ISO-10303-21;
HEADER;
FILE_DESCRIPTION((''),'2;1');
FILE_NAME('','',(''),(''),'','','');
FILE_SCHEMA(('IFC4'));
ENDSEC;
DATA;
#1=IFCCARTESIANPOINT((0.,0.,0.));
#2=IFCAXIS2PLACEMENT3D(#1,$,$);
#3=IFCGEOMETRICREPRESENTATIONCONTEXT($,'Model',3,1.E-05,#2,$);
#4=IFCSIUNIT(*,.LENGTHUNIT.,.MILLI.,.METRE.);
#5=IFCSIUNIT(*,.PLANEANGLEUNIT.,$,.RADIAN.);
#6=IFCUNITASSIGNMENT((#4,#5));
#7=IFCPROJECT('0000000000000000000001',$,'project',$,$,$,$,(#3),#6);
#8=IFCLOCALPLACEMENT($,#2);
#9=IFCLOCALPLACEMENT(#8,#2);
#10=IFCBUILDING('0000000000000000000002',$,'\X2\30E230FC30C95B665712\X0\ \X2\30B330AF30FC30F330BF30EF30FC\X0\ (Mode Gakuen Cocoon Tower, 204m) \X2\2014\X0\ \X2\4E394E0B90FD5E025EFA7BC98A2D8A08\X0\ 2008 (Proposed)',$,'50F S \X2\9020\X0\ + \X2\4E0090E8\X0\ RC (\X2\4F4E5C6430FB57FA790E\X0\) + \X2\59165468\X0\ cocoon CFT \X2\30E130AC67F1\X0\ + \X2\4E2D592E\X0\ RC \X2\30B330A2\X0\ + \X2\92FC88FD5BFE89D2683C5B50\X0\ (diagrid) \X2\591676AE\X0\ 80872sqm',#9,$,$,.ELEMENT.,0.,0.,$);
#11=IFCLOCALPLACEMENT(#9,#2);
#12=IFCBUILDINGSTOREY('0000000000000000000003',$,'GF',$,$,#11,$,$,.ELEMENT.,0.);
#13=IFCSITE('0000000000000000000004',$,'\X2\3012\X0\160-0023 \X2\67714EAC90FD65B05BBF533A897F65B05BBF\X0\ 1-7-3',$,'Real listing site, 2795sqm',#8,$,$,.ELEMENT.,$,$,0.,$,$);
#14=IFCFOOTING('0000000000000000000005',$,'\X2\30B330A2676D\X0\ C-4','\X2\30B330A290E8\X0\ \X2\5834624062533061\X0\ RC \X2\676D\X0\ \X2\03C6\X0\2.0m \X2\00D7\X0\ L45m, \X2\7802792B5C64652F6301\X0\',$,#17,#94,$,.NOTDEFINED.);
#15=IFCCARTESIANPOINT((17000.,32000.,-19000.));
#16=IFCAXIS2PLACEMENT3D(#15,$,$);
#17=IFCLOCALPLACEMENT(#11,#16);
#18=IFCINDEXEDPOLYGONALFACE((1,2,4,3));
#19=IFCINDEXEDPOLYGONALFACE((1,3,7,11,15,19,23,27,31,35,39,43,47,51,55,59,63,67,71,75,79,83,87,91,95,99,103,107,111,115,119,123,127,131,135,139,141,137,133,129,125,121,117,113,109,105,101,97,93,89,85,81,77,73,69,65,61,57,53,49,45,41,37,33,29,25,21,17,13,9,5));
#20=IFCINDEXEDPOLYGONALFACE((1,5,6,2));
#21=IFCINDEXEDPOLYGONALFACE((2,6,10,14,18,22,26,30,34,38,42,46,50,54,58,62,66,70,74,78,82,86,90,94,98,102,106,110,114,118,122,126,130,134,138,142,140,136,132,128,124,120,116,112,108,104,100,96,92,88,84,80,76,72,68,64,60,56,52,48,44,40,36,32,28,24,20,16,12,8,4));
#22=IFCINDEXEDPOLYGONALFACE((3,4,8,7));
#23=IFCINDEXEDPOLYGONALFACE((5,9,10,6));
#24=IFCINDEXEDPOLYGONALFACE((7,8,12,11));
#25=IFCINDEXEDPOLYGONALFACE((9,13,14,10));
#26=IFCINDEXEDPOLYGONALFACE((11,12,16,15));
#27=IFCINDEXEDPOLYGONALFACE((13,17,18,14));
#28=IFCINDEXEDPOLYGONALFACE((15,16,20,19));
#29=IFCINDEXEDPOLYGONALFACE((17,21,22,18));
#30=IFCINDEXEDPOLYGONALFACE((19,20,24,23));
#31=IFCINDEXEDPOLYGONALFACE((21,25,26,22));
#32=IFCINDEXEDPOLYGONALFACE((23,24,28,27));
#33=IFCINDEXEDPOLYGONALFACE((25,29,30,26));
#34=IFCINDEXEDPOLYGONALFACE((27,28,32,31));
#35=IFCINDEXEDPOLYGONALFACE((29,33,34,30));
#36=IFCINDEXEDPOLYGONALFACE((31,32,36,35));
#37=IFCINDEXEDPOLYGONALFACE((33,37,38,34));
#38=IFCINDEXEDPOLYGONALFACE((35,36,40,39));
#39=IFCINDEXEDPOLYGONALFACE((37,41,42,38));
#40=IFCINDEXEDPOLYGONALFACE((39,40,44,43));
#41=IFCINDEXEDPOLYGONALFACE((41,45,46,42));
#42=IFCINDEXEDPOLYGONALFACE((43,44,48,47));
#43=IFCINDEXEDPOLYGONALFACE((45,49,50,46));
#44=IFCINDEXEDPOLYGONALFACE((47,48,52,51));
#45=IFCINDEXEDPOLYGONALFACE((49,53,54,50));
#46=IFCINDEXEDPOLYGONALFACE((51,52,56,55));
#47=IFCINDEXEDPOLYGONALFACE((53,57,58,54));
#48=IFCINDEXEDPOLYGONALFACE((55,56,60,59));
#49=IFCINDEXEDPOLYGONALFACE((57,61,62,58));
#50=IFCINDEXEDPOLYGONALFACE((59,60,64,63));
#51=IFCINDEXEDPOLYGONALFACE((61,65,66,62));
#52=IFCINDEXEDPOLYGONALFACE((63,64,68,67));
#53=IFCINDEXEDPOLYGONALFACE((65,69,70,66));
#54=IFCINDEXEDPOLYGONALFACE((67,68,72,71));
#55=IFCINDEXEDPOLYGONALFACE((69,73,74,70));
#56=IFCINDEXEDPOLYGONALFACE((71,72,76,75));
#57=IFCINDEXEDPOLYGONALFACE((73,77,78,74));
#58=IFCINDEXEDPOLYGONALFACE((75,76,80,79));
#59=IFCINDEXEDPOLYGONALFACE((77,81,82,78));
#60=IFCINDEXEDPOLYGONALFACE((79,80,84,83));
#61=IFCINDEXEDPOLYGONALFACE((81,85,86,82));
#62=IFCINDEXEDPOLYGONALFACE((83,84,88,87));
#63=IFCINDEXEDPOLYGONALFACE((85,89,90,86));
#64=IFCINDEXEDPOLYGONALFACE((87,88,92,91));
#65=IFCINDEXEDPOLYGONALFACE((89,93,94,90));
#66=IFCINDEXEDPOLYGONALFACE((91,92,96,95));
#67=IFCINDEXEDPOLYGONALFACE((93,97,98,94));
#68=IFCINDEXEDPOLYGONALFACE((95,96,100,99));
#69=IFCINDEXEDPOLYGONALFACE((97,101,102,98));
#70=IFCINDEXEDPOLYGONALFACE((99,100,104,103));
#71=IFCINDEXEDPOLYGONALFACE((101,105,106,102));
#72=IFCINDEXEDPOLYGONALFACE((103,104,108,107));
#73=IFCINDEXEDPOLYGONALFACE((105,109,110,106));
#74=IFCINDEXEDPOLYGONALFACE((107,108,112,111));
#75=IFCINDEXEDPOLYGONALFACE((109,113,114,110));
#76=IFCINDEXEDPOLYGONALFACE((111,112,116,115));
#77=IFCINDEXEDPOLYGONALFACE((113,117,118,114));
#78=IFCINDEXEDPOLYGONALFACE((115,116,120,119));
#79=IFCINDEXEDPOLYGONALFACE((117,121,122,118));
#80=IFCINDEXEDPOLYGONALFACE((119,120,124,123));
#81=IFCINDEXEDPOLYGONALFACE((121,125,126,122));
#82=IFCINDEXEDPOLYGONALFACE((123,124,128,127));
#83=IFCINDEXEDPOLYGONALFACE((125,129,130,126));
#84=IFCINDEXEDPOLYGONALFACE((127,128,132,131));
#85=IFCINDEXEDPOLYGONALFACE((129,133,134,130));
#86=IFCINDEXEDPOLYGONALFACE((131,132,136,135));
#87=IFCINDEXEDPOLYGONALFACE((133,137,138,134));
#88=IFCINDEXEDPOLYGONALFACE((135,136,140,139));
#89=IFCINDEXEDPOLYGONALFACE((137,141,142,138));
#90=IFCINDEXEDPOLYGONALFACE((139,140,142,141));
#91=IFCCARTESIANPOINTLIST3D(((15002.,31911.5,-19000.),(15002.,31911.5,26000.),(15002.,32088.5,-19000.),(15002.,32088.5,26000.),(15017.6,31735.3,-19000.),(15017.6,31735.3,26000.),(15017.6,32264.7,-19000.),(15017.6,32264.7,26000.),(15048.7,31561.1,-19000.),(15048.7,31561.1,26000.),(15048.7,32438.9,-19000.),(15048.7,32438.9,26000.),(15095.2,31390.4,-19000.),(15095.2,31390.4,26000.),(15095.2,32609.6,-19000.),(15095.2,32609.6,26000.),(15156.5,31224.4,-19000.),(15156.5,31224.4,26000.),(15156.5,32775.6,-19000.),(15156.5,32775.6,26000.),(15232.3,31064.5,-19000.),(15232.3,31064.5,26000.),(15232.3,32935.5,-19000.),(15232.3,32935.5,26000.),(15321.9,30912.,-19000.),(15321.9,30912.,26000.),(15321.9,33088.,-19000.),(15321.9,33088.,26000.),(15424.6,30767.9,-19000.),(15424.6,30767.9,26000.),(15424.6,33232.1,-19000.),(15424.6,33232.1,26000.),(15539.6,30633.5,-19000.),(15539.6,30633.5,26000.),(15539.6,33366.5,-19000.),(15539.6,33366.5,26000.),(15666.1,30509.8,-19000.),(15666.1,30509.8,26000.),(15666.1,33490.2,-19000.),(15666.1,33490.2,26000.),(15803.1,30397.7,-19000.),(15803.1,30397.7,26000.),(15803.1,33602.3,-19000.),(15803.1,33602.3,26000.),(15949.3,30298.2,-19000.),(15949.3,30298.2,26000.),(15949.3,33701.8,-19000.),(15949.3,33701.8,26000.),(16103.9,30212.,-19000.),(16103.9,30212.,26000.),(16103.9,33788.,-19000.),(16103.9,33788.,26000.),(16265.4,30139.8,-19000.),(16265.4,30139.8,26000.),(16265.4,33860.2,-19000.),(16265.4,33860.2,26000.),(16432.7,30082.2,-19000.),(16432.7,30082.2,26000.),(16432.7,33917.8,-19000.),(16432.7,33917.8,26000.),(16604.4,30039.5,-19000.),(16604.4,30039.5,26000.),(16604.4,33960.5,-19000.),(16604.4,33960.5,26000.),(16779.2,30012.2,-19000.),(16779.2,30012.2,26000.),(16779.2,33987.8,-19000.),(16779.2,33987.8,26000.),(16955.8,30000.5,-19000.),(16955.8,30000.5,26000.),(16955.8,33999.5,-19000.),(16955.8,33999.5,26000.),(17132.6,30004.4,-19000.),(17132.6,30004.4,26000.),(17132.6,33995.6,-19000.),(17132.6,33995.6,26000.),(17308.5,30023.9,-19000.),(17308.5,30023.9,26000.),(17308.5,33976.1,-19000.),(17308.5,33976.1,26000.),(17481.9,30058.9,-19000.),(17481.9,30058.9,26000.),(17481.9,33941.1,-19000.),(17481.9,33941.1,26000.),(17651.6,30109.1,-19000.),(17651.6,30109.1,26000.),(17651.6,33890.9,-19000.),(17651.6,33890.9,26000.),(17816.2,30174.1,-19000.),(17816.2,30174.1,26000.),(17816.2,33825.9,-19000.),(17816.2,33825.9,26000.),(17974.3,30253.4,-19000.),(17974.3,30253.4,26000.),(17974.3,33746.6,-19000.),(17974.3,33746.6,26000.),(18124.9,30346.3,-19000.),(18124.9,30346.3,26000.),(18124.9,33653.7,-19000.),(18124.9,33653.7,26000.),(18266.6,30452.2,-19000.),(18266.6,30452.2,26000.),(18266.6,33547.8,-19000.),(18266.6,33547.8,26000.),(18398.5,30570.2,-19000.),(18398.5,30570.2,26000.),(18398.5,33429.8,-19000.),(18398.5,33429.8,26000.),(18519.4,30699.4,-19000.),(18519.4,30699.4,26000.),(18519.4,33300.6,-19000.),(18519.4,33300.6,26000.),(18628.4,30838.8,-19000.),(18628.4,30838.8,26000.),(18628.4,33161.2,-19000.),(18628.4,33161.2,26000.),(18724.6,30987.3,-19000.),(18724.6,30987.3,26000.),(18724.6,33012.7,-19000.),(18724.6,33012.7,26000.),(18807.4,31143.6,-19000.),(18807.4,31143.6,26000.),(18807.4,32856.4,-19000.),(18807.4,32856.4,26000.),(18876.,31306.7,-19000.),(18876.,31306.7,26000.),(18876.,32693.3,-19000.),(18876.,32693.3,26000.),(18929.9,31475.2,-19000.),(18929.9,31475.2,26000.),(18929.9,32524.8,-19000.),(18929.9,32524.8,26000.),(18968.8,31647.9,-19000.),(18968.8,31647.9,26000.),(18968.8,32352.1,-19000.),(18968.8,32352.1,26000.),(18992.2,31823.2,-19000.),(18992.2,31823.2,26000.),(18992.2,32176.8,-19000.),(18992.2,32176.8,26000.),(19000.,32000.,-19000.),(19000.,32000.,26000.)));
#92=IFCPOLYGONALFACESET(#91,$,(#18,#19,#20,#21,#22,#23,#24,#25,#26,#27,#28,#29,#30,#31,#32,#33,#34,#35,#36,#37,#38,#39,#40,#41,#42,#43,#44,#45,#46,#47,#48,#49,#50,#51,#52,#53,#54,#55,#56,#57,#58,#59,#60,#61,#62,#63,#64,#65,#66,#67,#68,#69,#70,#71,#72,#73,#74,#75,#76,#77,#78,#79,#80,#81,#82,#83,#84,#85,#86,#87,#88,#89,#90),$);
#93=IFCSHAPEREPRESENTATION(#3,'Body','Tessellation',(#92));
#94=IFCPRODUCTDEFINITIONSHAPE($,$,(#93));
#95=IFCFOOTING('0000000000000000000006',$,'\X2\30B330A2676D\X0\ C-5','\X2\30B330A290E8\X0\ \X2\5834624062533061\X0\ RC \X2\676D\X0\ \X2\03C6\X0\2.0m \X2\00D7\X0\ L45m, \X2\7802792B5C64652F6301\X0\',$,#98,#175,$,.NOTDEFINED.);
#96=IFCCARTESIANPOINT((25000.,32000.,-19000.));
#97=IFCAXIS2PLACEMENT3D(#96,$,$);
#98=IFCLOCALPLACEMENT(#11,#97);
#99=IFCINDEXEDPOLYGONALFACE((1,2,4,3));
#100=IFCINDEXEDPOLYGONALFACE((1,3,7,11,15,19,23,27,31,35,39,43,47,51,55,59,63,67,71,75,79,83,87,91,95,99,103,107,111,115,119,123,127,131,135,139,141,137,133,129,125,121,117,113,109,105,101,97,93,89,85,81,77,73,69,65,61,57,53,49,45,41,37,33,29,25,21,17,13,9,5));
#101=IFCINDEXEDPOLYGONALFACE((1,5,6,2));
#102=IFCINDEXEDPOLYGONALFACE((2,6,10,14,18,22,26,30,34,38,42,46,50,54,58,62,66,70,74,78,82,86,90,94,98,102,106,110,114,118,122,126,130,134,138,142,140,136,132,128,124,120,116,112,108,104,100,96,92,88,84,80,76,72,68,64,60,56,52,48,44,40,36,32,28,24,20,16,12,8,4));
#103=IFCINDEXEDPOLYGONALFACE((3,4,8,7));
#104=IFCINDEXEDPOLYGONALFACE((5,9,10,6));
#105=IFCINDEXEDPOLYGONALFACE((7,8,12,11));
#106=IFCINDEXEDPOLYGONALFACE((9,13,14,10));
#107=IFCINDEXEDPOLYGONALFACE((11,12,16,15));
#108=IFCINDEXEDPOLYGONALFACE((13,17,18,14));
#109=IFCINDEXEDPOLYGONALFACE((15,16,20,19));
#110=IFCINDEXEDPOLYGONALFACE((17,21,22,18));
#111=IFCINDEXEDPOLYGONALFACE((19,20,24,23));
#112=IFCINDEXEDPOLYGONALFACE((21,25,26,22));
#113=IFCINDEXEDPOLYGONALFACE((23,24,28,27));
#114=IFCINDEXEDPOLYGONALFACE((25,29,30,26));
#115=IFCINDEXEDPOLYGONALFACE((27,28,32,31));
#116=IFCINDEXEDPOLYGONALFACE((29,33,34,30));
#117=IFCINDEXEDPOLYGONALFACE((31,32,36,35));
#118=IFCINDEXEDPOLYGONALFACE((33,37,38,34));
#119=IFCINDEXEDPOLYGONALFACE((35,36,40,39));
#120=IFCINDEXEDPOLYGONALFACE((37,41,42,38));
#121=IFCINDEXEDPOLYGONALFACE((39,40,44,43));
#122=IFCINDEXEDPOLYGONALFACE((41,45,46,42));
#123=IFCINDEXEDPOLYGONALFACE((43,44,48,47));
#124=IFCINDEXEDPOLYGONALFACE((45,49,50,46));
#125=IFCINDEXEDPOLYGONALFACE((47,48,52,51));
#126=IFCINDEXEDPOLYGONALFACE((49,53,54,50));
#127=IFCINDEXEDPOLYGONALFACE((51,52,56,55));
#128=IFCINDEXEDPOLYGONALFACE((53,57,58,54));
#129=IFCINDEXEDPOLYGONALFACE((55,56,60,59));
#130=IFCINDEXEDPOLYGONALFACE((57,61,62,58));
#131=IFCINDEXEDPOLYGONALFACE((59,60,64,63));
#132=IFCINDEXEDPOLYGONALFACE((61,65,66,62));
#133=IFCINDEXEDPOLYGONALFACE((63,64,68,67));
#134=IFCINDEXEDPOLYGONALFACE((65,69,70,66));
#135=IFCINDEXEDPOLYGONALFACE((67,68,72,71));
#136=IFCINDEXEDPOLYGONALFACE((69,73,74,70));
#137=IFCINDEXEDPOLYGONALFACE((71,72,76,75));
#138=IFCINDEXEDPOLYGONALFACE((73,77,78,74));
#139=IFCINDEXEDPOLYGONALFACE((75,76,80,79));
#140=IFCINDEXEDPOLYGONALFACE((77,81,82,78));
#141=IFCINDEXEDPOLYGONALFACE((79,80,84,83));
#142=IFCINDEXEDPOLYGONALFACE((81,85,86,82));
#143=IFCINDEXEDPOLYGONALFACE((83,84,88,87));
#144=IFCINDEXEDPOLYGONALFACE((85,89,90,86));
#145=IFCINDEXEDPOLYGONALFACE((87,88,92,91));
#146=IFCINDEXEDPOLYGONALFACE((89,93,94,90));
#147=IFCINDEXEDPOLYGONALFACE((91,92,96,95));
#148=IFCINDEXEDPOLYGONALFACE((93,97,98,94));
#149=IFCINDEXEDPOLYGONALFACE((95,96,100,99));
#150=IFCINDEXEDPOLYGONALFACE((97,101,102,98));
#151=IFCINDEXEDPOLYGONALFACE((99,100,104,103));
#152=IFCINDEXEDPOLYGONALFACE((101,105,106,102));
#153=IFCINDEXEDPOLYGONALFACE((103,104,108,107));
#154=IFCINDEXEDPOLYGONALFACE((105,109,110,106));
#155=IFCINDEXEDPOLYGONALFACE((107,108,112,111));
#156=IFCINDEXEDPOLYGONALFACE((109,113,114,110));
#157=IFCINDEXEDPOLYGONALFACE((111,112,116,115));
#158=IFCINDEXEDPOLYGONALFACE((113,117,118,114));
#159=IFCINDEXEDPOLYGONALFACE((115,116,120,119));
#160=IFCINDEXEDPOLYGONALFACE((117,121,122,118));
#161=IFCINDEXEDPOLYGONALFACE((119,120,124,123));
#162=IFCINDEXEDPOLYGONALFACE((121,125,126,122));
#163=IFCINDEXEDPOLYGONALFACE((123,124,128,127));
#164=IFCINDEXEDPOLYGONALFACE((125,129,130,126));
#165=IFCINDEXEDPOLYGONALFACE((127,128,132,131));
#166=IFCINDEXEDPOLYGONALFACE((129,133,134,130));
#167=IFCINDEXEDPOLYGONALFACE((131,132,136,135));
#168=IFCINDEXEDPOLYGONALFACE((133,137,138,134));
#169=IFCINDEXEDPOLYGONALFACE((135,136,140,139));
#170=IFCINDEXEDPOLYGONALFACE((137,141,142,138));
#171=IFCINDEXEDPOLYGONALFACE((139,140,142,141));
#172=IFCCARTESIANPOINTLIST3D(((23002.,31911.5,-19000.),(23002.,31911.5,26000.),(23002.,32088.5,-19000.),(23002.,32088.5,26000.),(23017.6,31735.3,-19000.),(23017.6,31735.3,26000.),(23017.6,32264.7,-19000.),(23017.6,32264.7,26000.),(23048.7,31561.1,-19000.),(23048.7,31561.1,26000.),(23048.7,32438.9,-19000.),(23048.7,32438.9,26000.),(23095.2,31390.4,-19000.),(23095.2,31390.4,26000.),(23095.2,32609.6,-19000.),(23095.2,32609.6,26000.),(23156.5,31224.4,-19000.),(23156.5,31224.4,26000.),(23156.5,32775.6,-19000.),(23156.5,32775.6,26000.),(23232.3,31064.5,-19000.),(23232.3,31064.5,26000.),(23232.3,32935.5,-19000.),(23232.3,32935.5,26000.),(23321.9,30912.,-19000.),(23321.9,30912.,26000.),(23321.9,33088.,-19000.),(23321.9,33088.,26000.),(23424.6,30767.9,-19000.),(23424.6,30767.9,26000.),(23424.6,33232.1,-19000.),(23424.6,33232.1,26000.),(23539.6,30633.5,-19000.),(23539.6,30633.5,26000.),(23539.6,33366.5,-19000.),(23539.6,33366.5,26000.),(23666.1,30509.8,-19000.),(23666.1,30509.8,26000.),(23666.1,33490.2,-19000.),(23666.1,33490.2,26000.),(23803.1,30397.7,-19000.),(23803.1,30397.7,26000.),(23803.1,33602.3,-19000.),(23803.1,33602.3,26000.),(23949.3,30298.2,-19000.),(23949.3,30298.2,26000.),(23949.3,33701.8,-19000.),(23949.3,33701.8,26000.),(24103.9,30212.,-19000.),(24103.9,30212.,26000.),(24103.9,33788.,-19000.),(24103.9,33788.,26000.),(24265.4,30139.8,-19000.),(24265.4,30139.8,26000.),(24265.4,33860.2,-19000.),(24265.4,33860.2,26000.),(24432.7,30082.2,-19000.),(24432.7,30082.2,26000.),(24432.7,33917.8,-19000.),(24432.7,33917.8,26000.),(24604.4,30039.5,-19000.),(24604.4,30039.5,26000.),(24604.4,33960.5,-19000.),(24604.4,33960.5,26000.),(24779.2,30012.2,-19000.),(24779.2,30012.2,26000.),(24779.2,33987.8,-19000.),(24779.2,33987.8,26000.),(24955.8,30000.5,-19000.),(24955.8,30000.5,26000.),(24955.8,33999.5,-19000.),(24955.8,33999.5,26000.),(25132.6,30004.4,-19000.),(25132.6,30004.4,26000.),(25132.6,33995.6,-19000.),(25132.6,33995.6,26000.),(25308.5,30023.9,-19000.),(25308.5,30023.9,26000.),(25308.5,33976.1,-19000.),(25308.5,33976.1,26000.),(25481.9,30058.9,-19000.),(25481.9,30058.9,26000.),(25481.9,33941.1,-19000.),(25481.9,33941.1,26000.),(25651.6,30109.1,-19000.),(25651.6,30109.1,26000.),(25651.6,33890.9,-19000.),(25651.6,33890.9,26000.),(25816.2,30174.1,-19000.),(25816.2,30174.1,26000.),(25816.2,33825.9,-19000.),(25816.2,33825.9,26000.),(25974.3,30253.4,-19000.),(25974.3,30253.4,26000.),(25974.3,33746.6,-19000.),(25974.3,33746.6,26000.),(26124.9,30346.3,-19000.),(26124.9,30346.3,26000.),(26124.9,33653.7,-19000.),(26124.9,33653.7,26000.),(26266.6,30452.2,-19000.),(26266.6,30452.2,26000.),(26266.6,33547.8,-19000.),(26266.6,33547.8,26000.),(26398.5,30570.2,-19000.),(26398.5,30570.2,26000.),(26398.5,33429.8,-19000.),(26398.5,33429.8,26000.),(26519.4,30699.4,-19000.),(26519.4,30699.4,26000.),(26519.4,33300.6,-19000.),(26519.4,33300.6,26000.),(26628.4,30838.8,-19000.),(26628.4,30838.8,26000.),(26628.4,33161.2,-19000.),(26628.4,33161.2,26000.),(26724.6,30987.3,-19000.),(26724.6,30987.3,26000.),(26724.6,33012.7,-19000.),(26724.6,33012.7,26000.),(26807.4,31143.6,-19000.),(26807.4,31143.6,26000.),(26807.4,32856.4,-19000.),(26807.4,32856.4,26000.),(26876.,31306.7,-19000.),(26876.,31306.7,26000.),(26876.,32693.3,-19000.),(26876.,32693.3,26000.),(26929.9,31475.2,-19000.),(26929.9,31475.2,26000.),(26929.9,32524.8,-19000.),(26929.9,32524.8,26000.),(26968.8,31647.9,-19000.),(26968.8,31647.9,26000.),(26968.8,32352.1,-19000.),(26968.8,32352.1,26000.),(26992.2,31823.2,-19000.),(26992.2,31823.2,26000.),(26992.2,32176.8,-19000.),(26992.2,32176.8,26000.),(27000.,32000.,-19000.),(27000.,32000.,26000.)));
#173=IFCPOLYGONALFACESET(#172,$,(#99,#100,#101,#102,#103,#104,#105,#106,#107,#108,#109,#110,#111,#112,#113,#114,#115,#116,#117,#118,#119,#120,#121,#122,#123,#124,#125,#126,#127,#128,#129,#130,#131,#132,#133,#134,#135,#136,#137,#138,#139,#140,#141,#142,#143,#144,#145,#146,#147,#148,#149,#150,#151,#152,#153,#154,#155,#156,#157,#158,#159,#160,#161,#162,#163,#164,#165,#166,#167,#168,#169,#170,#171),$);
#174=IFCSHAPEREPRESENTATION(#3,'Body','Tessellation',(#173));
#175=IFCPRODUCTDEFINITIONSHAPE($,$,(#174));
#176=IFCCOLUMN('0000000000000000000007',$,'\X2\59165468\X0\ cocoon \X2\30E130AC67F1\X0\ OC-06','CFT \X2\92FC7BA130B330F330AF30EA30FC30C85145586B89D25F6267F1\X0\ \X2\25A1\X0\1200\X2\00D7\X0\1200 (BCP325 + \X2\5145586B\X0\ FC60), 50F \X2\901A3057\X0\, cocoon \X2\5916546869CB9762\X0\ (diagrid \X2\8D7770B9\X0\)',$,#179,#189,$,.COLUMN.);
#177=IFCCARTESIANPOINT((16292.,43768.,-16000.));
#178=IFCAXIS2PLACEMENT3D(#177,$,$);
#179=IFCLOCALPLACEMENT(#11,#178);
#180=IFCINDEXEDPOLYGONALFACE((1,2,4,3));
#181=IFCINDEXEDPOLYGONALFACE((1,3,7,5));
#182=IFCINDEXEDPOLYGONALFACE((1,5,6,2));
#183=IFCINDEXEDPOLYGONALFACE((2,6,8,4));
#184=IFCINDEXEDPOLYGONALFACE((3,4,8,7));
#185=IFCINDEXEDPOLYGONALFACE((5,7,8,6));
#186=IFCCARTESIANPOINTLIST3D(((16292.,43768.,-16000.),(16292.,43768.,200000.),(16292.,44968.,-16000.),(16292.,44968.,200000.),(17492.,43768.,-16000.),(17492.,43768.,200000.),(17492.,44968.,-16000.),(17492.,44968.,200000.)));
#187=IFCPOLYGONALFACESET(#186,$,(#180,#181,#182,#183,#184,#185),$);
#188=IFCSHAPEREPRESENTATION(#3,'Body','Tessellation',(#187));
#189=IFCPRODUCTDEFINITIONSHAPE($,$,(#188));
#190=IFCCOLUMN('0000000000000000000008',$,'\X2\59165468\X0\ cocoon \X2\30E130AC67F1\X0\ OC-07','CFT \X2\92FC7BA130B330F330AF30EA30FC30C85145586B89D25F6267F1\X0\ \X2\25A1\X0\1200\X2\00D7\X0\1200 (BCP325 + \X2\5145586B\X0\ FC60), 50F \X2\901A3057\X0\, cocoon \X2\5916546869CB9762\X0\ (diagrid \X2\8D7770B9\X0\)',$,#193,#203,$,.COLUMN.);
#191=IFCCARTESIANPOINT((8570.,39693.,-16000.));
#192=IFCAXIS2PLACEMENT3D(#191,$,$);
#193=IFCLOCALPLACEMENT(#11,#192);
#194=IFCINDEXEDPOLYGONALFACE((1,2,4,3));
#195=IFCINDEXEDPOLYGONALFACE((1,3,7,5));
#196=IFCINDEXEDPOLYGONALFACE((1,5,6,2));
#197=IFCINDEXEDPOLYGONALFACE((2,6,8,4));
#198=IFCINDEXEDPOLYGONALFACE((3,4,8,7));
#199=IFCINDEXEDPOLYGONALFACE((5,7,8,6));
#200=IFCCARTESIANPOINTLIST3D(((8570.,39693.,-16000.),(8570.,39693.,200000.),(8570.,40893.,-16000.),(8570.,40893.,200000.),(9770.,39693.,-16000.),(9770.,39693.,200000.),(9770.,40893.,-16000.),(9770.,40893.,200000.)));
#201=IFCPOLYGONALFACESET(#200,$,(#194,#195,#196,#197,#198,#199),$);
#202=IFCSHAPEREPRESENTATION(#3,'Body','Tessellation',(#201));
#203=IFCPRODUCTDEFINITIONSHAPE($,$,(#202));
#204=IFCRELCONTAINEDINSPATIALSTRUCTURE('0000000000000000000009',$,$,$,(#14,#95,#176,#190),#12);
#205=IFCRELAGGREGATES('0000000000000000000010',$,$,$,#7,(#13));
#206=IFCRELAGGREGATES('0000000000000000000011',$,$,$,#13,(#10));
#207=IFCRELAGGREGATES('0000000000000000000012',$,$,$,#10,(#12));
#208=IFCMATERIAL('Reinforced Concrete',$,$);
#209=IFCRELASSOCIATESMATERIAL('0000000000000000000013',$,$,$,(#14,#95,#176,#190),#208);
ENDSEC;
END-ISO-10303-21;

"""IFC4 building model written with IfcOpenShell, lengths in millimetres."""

from ifc_helpers import new_model, si_unit, frame, frame_2d, origin, origin_2d, place, context, project, spatial, rectangle, circle, extrude, material, element, save


model = new_model("IFC4")

# Units and contexts
model_context = context("Model", 3, precision=1e-05, world=origin())
ifc_project = project(units=[si_unit("LENGTHUNIT", "METRE", prefix="MILLI"), si_unit("PLANEANGLEUNIT", "RADIAN")], contexts=[model_context])

# Site, building, storey
site_placement = place(None, origin())
site = spatial("IfcSite", under=ifc_project, at=site_placement, Name="〒160-0023 東京都新宿区西新宿 1-7-3", ObjectType="Real listing site, 2795sqm", CompositionType="ELEMENT", RefElevation=0.0)
building_placement = place(site_placement, origin())
building = spatial("IfcBuilding", under=site, at=building_placement, Name="モード学園 コクーンタワー (Mode Gakuen Cocoon Tower, 204m) — 丹下都市建築設計 2008 (Proposed)", ObjectType="50F S 造 + 一部 RC (低層・基礎) + 外周 cocoon CFT メガ柱 + 中央 RC コア + 鋼製対角格子 (diagrid) 外皮 80872sqm", CompositionType="ELEMENT", ElevationOfRefHeight=0.0, ElevationOfTerrain=0.0)
storey_placement = place(building_placement, origin())
storey = spatial("IfcBuildingStorey", under=building, at=storey_placement, Name="GF", CompositionType="ELEMENT", Elevation=0.0)

# Footings
ifc_material_1 = material(Name="Reinforced Concrete")
footing_1_placement = place(storey_placement, frame((17000.0, 32000.0, -19000.0)))
element("IfcFooting", 1, at=footing_1_placement, inside=storey, material=ifc_material_1, Name="コア杭 C-4", Description="コア部 場所打ち RC 杭 φ2.0m × L45m, 砂礫層支持", PredefinedType="NOTDEFINED", context=model_context, shape_type="SweptSolid", body=[
    extrude(circle(Radius=2000.0, at=origin_2d()), frame((17000.0, 32000.0, -19000.0)), (0.0, 0.0, 1.0), 45000.0),
])
footing_2_placement = place(storey_placement, frame((25000.0, 32000.0, -19000.0)))
element("IfcFooting", 2, at=footing_2_placement, inside=storey, material=ifc_material_1, Name="コア杭 C-5", Description="コア部 場所打ち RC 杭 φ2.0m × L45m, 砂礫層支持", PredefinedType="NOTDEFINED", context=model_context, shape_type="SweptSolid", body=[
    extrude(circle(Radius=2000.0, at=origin_2d()), frame((25000.0, 32000.0, -19000.0)), (0.0, 0.0, 1.0), 45000.0),
])

# Columns
column_1_placement = place(storey_placement, frame((16292.0, 43768.0, -16000.0)))
element("IfcColumn", 3, at=column_1_placement, inside=storey, material=ifc_material_1, Name="外周 cocoon メガ柱 OC-06", Description="CFT 鋼管コンクリート充填角形柱 □1200×1200 (BCP325 + 充填 FC60), 50F 通し, cocoon 外周構面 (diagrid 起点)", PredefinedType="COLUMN", context=model_context, shape_type="SweptSolid", body=[
    extrude(rectangle(XDim=1200.0, YDim=1200.0, at=frame_2d((600.0, 600.0))), frame((16292.0, 43768.0, -16000.0)), (0.0, 0.0, 1.0), 216000.0),
])
column_2_placement = place(storey_placement, frame((8570.0, 39693.0, -16000.0)))
element("IfcColumn", 4, at=column_2_placement, inside=storey, material=ifc_material_1, Name="外周 cocoon メガ柱 OC-07", Description="CFT 鋼管コンクリート充填角形柱 □1200×1200 (BCP325 + 充填 FC60), 50F 通し, cocoon 外周構面 (diagrid 起点)", PredefinedType="COLUMN", context=model_context, shape_type="SweptSolid", body=[
    extrude(rectangle(XDim=1200.0, YDim=1200.0, at=frame_2d((600.0, 600.0))), frame((8570.0, 39693.0, -16000.0)), (0.0, 0.0, 1.0), 216000.0),
])

save(model, "model.ifc")
